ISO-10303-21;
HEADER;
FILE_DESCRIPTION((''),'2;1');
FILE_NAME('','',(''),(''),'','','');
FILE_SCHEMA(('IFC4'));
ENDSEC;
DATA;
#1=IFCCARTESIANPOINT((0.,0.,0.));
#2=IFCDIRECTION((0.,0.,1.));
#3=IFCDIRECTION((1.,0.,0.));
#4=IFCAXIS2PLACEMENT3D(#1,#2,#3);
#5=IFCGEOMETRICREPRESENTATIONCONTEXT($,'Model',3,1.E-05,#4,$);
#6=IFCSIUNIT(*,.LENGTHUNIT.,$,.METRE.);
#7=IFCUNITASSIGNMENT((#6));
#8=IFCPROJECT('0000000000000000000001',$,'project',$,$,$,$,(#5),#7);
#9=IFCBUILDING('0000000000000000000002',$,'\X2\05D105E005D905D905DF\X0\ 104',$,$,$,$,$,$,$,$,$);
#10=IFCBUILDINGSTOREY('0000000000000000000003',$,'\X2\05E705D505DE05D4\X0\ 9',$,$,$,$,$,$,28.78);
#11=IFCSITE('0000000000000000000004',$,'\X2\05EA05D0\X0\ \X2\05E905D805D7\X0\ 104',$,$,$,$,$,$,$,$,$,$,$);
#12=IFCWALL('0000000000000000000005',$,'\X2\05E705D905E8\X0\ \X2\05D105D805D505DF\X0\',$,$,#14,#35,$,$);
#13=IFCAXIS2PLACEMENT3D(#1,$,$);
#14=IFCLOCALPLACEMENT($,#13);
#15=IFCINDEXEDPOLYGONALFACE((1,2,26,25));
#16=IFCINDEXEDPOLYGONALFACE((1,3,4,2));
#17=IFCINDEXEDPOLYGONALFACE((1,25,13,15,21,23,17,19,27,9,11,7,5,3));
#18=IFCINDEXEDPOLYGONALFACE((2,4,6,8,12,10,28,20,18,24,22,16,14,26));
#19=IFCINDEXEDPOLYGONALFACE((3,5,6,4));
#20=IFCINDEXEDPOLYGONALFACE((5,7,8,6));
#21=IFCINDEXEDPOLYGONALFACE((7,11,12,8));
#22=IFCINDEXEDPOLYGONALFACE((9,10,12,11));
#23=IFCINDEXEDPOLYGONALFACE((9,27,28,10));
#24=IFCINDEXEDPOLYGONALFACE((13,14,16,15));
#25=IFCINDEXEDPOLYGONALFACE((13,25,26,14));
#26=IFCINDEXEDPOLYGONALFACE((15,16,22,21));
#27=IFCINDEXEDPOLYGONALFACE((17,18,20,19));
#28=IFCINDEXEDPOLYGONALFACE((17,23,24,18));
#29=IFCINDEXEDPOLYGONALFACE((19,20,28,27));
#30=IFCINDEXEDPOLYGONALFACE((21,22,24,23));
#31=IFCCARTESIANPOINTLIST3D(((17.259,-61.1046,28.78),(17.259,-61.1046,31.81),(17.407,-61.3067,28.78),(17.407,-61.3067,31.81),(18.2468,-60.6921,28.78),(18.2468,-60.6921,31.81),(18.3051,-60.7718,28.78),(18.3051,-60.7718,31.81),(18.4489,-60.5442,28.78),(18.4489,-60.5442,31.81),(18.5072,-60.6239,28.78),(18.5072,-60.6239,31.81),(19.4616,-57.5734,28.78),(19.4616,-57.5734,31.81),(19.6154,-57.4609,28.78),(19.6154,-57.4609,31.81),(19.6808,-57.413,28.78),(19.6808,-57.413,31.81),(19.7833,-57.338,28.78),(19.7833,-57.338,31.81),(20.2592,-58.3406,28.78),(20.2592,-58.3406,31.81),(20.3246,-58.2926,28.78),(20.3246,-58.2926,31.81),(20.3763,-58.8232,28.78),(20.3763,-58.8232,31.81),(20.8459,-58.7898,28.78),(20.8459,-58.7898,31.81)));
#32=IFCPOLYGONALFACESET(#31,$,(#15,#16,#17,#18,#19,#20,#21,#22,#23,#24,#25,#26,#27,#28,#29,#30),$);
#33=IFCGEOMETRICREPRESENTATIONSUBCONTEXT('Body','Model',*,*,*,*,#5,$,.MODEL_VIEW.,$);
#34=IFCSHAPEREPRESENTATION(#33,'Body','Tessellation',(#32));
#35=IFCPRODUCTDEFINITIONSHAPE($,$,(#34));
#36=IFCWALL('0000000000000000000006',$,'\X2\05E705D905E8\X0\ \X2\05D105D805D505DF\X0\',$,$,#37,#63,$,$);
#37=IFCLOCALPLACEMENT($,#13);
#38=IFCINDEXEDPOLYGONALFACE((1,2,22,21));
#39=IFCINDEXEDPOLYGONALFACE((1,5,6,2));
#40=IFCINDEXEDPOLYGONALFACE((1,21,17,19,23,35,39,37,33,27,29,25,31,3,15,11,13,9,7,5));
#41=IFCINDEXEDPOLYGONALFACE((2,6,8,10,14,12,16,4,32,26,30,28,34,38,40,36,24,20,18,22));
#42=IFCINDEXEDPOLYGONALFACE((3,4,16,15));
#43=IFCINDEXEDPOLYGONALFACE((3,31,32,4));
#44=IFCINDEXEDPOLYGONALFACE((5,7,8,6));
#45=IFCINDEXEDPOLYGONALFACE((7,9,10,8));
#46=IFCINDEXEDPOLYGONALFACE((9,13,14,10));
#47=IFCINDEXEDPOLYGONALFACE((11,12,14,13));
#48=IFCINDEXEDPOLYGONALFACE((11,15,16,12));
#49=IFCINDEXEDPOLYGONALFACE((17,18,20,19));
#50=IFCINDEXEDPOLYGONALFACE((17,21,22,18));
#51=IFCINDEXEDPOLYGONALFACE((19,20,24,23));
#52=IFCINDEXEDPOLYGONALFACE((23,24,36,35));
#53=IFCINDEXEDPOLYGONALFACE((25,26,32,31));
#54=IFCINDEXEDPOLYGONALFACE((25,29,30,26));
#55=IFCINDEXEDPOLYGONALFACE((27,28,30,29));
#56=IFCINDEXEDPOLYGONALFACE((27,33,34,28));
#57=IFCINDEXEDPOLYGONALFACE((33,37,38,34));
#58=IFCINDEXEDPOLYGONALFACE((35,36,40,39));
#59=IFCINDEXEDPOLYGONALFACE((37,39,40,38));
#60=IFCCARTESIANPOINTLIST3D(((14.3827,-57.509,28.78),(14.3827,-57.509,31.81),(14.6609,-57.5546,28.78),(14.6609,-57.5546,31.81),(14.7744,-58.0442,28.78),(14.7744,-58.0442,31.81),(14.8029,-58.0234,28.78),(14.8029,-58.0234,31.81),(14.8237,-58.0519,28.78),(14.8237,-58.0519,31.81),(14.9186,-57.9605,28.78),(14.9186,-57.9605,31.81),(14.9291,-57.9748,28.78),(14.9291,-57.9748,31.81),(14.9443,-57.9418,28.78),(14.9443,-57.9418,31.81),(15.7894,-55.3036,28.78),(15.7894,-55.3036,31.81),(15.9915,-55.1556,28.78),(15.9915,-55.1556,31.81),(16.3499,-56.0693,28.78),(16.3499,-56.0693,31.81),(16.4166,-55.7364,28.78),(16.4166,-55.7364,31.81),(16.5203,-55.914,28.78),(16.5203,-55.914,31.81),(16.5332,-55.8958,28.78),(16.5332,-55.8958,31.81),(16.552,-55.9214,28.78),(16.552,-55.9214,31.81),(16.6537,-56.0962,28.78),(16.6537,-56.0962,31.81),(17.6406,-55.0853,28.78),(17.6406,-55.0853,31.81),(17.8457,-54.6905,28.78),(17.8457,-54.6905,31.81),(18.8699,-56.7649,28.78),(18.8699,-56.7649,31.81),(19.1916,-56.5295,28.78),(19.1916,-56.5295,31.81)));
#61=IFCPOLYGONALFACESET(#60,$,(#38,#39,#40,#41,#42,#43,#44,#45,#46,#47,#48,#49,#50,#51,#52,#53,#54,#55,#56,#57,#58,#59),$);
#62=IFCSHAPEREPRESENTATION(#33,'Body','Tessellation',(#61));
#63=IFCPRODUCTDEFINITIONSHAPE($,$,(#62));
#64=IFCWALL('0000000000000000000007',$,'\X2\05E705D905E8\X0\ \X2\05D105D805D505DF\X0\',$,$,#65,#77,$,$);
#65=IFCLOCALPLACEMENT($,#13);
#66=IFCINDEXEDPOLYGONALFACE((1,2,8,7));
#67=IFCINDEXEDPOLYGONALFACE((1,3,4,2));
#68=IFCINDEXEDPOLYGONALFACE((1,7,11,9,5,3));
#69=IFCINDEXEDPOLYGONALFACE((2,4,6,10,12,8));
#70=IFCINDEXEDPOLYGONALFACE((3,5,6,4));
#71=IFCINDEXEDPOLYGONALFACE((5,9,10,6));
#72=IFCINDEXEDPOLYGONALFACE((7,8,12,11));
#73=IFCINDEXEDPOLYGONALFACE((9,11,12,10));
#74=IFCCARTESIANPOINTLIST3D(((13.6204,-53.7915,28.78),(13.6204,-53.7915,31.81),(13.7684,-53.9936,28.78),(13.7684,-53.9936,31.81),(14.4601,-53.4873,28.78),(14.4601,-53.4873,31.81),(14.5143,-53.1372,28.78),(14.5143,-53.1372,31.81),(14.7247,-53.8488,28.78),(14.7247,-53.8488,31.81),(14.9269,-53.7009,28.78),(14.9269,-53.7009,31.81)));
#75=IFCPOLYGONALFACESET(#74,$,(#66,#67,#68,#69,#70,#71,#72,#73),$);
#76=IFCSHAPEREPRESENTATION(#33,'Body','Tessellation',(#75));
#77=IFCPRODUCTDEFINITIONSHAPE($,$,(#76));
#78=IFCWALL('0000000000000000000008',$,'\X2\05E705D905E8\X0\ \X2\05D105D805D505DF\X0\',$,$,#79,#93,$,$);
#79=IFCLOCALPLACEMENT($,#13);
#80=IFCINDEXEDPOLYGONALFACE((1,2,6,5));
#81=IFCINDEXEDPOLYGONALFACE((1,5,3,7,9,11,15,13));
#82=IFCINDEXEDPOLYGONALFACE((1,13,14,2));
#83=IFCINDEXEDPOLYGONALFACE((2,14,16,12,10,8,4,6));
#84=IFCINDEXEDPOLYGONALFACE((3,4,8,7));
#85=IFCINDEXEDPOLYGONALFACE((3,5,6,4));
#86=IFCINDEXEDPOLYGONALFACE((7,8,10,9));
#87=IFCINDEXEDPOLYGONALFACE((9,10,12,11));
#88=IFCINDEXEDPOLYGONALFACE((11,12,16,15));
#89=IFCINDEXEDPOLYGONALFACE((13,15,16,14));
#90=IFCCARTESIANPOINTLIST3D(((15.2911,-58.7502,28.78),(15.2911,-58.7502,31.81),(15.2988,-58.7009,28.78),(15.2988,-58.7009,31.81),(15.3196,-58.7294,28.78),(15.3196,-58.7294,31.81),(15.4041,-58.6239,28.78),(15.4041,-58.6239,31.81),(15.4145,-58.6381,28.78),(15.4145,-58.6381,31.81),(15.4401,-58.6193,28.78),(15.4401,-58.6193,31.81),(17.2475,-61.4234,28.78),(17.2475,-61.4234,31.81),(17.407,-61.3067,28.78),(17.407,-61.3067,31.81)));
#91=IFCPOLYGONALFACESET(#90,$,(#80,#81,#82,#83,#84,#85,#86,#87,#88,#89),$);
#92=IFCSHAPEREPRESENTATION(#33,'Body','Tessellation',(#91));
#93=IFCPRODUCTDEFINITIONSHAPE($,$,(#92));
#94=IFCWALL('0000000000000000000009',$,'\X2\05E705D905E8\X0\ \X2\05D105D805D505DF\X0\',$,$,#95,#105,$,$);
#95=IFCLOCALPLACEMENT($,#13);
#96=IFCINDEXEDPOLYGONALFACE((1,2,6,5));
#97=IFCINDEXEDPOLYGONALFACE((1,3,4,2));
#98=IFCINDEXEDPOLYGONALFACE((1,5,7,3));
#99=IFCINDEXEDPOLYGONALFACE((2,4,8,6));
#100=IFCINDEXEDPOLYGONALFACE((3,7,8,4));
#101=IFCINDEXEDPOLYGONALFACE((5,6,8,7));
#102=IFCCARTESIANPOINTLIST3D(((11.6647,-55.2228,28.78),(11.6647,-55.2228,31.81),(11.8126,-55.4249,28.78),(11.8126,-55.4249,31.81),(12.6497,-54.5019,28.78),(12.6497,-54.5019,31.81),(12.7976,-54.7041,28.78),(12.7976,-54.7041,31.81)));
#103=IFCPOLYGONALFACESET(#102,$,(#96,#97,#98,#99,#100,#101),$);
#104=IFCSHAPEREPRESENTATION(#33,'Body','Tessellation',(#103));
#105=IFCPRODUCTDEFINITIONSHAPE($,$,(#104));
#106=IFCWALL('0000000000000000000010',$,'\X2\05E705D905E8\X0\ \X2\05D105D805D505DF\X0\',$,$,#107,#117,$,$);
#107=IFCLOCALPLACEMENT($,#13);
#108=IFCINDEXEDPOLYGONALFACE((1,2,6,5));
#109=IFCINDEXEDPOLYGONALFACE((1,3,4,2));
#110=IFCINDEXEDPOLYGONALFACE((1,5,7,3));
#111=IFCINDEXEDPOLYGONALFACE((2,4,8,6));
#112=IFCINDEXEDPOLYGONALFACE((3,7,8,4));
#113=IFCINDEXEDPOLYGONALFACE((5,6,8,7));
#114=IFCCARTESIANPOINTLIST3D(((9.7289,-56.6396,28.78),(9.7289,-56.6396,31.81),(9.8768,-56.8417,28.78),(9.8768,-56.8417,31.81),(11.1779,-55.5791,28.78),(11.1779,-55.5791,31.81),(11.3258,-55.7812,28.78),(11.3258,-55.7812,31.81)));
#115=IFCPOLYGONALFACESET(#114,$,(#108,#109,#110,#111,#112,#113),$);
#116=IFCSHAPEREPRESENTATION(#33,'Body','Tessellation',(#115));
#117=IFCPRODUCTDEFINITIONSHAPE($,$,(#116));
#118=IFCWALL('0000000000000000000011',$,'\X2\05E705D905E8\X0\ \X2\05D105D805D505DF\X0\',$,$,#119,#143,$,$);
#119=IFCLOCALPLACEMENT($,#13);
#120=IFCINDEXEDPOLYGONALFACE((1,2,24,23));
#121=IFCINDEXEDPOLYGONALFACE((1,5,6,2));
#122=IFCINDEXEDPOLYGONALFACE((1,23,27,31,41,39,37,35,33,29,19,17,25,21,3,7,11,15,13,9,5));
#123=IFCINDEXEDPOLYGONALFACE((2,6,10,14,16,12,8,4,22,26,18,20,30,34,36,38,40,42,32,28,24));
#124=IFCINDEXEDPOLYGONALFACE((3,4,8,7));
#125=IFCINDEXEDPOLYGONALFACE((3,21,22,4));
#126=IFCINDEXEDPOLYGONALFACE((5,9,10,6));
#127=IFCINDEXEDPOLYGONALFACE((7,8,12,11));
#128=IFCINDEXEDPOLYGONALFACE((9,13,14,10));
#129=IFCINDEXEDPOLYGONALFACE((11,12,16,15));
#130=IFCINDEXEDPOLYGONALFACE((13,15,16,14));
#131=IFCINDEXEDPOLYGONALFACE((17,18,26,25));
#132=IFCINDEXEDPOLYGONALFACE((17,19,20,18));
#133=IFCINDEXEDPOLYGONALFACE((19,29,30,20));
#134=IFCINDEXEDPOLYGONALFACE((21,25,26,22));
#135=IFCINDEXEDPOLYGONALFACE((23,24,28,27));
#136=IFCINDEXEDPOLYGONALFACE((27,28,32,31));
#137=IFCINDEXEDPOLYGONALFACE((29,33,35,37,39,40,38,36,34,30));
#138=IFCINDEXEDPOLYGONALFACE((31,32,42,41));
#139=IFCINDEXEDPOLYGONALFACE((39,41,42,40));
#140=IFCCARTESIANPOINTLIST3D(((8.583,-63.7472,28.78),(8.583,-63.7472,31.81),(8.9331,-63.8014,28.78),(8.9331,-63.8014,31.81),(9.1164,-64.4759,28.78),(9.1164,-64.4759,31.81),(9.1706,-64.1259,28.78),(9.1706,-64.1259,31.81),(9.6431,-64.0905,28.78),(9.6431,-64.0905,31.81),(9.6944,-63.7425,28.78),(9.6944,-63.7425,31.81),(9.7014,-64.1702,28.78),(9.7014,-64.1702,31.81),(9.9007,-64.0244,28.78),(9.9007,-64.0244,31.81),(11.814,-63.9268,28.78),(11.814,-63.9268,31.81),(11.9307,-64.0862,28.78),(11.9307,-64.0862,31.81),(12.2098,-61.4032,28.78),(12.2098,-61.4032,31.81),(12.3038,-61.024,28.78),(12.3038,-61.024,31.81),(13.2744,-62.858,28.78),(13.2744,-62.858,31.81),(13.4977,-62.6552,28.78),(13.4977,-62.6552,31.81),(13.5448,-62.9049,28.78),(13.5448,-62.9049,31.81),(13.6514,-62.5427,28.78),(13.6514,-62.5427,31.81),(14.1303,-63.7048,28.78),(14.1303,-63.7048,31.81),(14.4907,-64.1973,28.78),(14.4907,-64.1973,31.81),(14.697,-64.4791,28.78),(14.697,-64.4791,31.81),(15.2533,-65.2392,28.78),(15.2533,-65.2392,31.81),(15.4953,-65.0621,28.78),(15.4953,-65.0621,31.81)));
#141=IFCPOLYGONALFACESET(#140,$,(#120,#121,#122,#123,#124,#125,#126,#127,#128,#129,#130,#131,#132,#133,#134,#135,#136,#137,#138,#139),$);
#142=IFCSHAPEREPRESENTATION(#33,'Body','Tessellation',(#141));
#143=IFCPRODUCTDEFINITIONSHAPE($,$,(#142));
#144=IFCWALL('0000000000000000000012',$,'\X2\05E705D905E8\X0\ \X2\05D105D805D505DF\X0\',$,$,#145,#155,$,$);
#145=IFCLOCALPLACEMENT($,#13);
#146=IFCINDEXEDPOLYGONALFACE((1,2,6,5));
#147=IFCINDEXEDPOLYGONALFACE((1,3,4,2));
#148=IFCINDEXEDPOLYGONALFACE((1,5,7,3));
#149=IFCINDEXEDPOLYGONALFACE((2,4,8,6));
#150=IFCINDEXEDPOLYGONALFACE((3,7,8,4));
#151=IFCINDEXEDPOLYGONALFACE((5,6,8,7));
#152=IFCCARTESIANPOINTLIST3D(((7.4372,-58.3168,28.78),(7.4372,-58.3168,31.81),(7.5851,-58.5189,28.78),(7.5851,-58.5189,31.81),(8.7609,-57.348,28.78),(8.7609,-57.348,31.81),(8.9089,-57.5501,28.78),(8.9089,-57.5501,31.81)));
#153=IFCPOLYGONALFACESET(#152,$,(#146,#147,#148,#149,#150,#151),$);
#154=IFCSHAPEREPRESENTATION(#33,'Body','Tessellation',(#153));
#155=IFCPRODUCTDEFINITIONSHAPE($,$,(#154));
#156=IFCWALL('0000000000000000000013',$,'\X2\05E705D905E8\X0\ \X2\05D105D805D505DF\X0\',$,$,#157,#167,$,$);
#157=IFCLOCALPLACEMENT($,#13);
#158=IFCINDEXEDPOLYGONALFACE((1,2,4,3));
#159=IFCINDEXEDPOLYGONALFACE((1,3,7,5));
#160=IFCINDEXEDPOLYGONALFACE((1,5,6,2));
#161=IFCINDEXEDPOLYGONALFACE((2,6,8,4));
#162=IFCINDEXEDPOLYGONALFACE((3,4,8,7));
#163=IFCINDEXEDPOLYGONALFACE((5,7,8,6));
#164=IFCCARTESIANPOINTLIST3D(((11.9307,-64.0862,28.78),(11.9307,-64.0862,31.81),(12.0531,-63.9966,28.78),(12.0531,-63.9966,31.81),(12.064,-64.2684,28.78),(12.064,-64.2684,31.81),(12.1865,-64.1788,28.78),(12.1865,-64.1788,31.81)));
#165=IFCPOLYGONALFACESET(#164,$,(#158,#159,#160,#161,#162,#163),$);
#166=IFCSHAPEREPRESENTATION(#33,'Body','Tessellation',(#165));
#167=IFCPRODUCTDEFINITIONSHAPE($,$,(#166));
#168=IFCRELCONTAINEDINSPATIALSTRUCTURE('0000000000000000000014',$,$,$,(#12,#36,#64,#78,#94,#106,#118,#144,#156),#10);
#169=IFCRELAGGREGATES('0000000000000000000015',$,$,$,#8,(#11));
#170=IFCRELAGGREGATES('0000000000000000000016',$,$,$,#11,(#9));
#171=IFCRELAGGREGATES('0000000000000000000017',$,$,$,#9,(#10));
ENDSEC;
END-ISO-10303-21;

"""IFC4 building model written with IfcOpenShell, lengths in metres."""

from ifc_helpers import new_model, si_unit, frame, origin_with_axes, context, subcontext, project, spatial, polyline, outline, extrude, element, save


model = new_model("IFC4")

# Units and contexts
model_context = context("Model", 3, precision=1e-05, world=origin_with_axes())
body_context = subcontext(model_context, "Body", "Model", "MODEL_VIEW")
ifc_project = project(units=[si_unit("LENGTHUNIT", "METRE")], contexts=[model_context])

# Site, building, storey
site = spatial("IfcSite", under=ifc_project, Name="תא שטח 104")
building = spatial("IfcBuilding", under=site, Name="בניין 104")
storey = spatial("IfcBuildingStorey", under=building, Name="קומה 9", Elevation=28.78)

# Walls
element("IfcWall", 1, inside=storey, Name="קיר בטון", context=body_context, shape_type="SweptSolid", body=[
    extrude(outline(polyline([(20.2592, -58.3406), (19.6154, -57.4609), (19.4616, -57.5734), (20.3763, -58.8232), (17.259, -61.1046), (17.407, -61.3067), (18.2468, -60.6921), (18.3051, -60.7718), (18.5072, -60.6239), (18.4489, -60.5442), (20.8459, -58.7898), (19.7833, -57.338), (19.6808, -57.413), (20.3246, -58.2926), (20.2592, -58.3406)])), frame((0.0, 0.0, 28.78)), (0.0, 0.0, 1.0), 3.03),
])
element("IfcWall", 2, inside=storey, Name="קיר בטון", context=body_context, shape_type="SweptSolid", body=[
    extrude(outline(polyline([(17.8457, -54.6905), (16.4166, -55.7364), (15.9915, -55.1556), (15.7894, -55.3036), (16.3499, -56.0693), (14.3827, -57.509), (14.7744, -58.0442), (14.8029, -58.0234), (14.8237, -58.0519), (14.9291, -57.9748), (14.9186, -57.9605), (14.9443, -57.9418), (14.6609, -57.5546), (16.6537, -56.0962), (16.5203, -55.914), (16.552, -55.9214), (16.5332, -55.8958), (17.6406, -55.0853), (18.8699, -56.7649), (19.1916, -56.5295), (17.8457, -54.6905)])), frame((0.0, 0.0, 28.78)), (0.0, 0.0, 1.0), 3.03),
])
element("IfcWall", 3, inside=storey, Name="קיר בטון", context=body_context, shape_type="SweptSolid", body=[
    extrude(outline(polyline([(13.7684, -53.9936), (14.4601, -53.4873), (14.7247, -53.8488), (14.9269, -53.7009), (14.5143, -53.1372), (13.6204, -53.7915), (13.7684, -53.9936)])), frame((0.0, 0.0, 28.78)), (0.0, 0.0, 1.0), 3.03),
])
element("IfcWall", 4, inside=storey, Name="קיר בטון", context=body_context, shape_type="SweptSolid", body=[
    extrude(outline(polyline([(15.3196, -58.7294), (15.2911, -58.7502), (17.2475, -61.4234), (17.407, -61.3067), (15.4401, -58.6193), (15.4145, -58.6381), (15.4041, -58.6239), (15.2988, -58.7009), (15.3196, -58.7294)])), frame((0.0, 0.0, 28.78)), (0.0, 0.0, 1.0), 3.03),
])
element("IfcWall", 5, inside=storey, Name="קיר בטון", context=body_context, shape_type="SweptSolid", body=[
    extrude(outline(polyline([(11.8126, -55.4249), (12.7976, -54.7041), (12.6497, -54.5019), (11.6647, -55.2228), (11.8126, -55.4249)])), frame((0.0, 0.0, 28.78)), (0.0, 0.0, 1.0), 3.03),
])
element("IfcWall", 6, inside=storey, Name="קיר בטון", context=body_context, shape_type="SweptSolid", body=[
    extrude(outline(polyline([(11.3258, -55.7812), (11.1779, -55.5791), (9.7289, -56.6396), (9.8768, -56.8417), (11.3258, -55.7812)])), frame((0.0, 0.0, 28.78)), (0.0, 0.0, 1.0), 3.03),
])
element("IfcWall", 7, inside=storey, Name="קיר בטון", context=body_context, shape_type="SweptSolid", body=[
    extrude(outline(polyline([(11.814, -63.9268), (11.9307, -64.0862), (13.5448, -62.9049), (14.1303, -63.7048), (14.4907, -64.1973), (14.697, -64.4791), (15.2533, -65.2392), (15.4953, -65.0621), (13.6514, -62.5427), (13.4977, -62.6552), (12.3038, -61.024), (8.583, -63.7472), (9.1164, -64.4759), (9.6431, -64.0905), (9.7014, -64.1702), (9.9007, -64.0244), (9.6944, -63.7425), (9.1706, -64.1259), (8.9331, -63.8014), (12.2098, -61.4032), (13.2744, -62.858), (11.814, -63.9268)]), holes=[polyline([(13.4282, -62.7454), (13.4282, -62.7454), (13.5448, -62.9049), (13.4282, -62.7454)])]), frame((0.0, 0.0, 28.78)), (0.0, 0.0, 1.0), 3.03),
])
element("IfcWall", 8, inside=storey, Name="קיר בטון", context=body_context, shape_type="SweptSolid", body=[
    extrude(outline(polyline([(8.9089, -57.5501), (8.7609, -57.348), (7.4372, -58.3168), (7.5851, -58.5189), (8.9089, -57.5501)])), frame((0.0, 0.0, 28.78)), (0.0, 0.0, 1.0), 3.03),
])
element("IfcWall", 9, inside=storey, Name="קיר בטון", context=body_context, shape_type="SweptSolid", body=[
    extrude(outline(polyline([(11.9307, -64.0862), (12.064, -64.2684), (12.1865, -64.1788), (12.0531, -63.9966), (11.9307, -64.0862)])), frame((0.0, 0.0, 28.78)), (0.0, 0.0, 1.0), 3.03),
])

save(model, "model.ifc")
